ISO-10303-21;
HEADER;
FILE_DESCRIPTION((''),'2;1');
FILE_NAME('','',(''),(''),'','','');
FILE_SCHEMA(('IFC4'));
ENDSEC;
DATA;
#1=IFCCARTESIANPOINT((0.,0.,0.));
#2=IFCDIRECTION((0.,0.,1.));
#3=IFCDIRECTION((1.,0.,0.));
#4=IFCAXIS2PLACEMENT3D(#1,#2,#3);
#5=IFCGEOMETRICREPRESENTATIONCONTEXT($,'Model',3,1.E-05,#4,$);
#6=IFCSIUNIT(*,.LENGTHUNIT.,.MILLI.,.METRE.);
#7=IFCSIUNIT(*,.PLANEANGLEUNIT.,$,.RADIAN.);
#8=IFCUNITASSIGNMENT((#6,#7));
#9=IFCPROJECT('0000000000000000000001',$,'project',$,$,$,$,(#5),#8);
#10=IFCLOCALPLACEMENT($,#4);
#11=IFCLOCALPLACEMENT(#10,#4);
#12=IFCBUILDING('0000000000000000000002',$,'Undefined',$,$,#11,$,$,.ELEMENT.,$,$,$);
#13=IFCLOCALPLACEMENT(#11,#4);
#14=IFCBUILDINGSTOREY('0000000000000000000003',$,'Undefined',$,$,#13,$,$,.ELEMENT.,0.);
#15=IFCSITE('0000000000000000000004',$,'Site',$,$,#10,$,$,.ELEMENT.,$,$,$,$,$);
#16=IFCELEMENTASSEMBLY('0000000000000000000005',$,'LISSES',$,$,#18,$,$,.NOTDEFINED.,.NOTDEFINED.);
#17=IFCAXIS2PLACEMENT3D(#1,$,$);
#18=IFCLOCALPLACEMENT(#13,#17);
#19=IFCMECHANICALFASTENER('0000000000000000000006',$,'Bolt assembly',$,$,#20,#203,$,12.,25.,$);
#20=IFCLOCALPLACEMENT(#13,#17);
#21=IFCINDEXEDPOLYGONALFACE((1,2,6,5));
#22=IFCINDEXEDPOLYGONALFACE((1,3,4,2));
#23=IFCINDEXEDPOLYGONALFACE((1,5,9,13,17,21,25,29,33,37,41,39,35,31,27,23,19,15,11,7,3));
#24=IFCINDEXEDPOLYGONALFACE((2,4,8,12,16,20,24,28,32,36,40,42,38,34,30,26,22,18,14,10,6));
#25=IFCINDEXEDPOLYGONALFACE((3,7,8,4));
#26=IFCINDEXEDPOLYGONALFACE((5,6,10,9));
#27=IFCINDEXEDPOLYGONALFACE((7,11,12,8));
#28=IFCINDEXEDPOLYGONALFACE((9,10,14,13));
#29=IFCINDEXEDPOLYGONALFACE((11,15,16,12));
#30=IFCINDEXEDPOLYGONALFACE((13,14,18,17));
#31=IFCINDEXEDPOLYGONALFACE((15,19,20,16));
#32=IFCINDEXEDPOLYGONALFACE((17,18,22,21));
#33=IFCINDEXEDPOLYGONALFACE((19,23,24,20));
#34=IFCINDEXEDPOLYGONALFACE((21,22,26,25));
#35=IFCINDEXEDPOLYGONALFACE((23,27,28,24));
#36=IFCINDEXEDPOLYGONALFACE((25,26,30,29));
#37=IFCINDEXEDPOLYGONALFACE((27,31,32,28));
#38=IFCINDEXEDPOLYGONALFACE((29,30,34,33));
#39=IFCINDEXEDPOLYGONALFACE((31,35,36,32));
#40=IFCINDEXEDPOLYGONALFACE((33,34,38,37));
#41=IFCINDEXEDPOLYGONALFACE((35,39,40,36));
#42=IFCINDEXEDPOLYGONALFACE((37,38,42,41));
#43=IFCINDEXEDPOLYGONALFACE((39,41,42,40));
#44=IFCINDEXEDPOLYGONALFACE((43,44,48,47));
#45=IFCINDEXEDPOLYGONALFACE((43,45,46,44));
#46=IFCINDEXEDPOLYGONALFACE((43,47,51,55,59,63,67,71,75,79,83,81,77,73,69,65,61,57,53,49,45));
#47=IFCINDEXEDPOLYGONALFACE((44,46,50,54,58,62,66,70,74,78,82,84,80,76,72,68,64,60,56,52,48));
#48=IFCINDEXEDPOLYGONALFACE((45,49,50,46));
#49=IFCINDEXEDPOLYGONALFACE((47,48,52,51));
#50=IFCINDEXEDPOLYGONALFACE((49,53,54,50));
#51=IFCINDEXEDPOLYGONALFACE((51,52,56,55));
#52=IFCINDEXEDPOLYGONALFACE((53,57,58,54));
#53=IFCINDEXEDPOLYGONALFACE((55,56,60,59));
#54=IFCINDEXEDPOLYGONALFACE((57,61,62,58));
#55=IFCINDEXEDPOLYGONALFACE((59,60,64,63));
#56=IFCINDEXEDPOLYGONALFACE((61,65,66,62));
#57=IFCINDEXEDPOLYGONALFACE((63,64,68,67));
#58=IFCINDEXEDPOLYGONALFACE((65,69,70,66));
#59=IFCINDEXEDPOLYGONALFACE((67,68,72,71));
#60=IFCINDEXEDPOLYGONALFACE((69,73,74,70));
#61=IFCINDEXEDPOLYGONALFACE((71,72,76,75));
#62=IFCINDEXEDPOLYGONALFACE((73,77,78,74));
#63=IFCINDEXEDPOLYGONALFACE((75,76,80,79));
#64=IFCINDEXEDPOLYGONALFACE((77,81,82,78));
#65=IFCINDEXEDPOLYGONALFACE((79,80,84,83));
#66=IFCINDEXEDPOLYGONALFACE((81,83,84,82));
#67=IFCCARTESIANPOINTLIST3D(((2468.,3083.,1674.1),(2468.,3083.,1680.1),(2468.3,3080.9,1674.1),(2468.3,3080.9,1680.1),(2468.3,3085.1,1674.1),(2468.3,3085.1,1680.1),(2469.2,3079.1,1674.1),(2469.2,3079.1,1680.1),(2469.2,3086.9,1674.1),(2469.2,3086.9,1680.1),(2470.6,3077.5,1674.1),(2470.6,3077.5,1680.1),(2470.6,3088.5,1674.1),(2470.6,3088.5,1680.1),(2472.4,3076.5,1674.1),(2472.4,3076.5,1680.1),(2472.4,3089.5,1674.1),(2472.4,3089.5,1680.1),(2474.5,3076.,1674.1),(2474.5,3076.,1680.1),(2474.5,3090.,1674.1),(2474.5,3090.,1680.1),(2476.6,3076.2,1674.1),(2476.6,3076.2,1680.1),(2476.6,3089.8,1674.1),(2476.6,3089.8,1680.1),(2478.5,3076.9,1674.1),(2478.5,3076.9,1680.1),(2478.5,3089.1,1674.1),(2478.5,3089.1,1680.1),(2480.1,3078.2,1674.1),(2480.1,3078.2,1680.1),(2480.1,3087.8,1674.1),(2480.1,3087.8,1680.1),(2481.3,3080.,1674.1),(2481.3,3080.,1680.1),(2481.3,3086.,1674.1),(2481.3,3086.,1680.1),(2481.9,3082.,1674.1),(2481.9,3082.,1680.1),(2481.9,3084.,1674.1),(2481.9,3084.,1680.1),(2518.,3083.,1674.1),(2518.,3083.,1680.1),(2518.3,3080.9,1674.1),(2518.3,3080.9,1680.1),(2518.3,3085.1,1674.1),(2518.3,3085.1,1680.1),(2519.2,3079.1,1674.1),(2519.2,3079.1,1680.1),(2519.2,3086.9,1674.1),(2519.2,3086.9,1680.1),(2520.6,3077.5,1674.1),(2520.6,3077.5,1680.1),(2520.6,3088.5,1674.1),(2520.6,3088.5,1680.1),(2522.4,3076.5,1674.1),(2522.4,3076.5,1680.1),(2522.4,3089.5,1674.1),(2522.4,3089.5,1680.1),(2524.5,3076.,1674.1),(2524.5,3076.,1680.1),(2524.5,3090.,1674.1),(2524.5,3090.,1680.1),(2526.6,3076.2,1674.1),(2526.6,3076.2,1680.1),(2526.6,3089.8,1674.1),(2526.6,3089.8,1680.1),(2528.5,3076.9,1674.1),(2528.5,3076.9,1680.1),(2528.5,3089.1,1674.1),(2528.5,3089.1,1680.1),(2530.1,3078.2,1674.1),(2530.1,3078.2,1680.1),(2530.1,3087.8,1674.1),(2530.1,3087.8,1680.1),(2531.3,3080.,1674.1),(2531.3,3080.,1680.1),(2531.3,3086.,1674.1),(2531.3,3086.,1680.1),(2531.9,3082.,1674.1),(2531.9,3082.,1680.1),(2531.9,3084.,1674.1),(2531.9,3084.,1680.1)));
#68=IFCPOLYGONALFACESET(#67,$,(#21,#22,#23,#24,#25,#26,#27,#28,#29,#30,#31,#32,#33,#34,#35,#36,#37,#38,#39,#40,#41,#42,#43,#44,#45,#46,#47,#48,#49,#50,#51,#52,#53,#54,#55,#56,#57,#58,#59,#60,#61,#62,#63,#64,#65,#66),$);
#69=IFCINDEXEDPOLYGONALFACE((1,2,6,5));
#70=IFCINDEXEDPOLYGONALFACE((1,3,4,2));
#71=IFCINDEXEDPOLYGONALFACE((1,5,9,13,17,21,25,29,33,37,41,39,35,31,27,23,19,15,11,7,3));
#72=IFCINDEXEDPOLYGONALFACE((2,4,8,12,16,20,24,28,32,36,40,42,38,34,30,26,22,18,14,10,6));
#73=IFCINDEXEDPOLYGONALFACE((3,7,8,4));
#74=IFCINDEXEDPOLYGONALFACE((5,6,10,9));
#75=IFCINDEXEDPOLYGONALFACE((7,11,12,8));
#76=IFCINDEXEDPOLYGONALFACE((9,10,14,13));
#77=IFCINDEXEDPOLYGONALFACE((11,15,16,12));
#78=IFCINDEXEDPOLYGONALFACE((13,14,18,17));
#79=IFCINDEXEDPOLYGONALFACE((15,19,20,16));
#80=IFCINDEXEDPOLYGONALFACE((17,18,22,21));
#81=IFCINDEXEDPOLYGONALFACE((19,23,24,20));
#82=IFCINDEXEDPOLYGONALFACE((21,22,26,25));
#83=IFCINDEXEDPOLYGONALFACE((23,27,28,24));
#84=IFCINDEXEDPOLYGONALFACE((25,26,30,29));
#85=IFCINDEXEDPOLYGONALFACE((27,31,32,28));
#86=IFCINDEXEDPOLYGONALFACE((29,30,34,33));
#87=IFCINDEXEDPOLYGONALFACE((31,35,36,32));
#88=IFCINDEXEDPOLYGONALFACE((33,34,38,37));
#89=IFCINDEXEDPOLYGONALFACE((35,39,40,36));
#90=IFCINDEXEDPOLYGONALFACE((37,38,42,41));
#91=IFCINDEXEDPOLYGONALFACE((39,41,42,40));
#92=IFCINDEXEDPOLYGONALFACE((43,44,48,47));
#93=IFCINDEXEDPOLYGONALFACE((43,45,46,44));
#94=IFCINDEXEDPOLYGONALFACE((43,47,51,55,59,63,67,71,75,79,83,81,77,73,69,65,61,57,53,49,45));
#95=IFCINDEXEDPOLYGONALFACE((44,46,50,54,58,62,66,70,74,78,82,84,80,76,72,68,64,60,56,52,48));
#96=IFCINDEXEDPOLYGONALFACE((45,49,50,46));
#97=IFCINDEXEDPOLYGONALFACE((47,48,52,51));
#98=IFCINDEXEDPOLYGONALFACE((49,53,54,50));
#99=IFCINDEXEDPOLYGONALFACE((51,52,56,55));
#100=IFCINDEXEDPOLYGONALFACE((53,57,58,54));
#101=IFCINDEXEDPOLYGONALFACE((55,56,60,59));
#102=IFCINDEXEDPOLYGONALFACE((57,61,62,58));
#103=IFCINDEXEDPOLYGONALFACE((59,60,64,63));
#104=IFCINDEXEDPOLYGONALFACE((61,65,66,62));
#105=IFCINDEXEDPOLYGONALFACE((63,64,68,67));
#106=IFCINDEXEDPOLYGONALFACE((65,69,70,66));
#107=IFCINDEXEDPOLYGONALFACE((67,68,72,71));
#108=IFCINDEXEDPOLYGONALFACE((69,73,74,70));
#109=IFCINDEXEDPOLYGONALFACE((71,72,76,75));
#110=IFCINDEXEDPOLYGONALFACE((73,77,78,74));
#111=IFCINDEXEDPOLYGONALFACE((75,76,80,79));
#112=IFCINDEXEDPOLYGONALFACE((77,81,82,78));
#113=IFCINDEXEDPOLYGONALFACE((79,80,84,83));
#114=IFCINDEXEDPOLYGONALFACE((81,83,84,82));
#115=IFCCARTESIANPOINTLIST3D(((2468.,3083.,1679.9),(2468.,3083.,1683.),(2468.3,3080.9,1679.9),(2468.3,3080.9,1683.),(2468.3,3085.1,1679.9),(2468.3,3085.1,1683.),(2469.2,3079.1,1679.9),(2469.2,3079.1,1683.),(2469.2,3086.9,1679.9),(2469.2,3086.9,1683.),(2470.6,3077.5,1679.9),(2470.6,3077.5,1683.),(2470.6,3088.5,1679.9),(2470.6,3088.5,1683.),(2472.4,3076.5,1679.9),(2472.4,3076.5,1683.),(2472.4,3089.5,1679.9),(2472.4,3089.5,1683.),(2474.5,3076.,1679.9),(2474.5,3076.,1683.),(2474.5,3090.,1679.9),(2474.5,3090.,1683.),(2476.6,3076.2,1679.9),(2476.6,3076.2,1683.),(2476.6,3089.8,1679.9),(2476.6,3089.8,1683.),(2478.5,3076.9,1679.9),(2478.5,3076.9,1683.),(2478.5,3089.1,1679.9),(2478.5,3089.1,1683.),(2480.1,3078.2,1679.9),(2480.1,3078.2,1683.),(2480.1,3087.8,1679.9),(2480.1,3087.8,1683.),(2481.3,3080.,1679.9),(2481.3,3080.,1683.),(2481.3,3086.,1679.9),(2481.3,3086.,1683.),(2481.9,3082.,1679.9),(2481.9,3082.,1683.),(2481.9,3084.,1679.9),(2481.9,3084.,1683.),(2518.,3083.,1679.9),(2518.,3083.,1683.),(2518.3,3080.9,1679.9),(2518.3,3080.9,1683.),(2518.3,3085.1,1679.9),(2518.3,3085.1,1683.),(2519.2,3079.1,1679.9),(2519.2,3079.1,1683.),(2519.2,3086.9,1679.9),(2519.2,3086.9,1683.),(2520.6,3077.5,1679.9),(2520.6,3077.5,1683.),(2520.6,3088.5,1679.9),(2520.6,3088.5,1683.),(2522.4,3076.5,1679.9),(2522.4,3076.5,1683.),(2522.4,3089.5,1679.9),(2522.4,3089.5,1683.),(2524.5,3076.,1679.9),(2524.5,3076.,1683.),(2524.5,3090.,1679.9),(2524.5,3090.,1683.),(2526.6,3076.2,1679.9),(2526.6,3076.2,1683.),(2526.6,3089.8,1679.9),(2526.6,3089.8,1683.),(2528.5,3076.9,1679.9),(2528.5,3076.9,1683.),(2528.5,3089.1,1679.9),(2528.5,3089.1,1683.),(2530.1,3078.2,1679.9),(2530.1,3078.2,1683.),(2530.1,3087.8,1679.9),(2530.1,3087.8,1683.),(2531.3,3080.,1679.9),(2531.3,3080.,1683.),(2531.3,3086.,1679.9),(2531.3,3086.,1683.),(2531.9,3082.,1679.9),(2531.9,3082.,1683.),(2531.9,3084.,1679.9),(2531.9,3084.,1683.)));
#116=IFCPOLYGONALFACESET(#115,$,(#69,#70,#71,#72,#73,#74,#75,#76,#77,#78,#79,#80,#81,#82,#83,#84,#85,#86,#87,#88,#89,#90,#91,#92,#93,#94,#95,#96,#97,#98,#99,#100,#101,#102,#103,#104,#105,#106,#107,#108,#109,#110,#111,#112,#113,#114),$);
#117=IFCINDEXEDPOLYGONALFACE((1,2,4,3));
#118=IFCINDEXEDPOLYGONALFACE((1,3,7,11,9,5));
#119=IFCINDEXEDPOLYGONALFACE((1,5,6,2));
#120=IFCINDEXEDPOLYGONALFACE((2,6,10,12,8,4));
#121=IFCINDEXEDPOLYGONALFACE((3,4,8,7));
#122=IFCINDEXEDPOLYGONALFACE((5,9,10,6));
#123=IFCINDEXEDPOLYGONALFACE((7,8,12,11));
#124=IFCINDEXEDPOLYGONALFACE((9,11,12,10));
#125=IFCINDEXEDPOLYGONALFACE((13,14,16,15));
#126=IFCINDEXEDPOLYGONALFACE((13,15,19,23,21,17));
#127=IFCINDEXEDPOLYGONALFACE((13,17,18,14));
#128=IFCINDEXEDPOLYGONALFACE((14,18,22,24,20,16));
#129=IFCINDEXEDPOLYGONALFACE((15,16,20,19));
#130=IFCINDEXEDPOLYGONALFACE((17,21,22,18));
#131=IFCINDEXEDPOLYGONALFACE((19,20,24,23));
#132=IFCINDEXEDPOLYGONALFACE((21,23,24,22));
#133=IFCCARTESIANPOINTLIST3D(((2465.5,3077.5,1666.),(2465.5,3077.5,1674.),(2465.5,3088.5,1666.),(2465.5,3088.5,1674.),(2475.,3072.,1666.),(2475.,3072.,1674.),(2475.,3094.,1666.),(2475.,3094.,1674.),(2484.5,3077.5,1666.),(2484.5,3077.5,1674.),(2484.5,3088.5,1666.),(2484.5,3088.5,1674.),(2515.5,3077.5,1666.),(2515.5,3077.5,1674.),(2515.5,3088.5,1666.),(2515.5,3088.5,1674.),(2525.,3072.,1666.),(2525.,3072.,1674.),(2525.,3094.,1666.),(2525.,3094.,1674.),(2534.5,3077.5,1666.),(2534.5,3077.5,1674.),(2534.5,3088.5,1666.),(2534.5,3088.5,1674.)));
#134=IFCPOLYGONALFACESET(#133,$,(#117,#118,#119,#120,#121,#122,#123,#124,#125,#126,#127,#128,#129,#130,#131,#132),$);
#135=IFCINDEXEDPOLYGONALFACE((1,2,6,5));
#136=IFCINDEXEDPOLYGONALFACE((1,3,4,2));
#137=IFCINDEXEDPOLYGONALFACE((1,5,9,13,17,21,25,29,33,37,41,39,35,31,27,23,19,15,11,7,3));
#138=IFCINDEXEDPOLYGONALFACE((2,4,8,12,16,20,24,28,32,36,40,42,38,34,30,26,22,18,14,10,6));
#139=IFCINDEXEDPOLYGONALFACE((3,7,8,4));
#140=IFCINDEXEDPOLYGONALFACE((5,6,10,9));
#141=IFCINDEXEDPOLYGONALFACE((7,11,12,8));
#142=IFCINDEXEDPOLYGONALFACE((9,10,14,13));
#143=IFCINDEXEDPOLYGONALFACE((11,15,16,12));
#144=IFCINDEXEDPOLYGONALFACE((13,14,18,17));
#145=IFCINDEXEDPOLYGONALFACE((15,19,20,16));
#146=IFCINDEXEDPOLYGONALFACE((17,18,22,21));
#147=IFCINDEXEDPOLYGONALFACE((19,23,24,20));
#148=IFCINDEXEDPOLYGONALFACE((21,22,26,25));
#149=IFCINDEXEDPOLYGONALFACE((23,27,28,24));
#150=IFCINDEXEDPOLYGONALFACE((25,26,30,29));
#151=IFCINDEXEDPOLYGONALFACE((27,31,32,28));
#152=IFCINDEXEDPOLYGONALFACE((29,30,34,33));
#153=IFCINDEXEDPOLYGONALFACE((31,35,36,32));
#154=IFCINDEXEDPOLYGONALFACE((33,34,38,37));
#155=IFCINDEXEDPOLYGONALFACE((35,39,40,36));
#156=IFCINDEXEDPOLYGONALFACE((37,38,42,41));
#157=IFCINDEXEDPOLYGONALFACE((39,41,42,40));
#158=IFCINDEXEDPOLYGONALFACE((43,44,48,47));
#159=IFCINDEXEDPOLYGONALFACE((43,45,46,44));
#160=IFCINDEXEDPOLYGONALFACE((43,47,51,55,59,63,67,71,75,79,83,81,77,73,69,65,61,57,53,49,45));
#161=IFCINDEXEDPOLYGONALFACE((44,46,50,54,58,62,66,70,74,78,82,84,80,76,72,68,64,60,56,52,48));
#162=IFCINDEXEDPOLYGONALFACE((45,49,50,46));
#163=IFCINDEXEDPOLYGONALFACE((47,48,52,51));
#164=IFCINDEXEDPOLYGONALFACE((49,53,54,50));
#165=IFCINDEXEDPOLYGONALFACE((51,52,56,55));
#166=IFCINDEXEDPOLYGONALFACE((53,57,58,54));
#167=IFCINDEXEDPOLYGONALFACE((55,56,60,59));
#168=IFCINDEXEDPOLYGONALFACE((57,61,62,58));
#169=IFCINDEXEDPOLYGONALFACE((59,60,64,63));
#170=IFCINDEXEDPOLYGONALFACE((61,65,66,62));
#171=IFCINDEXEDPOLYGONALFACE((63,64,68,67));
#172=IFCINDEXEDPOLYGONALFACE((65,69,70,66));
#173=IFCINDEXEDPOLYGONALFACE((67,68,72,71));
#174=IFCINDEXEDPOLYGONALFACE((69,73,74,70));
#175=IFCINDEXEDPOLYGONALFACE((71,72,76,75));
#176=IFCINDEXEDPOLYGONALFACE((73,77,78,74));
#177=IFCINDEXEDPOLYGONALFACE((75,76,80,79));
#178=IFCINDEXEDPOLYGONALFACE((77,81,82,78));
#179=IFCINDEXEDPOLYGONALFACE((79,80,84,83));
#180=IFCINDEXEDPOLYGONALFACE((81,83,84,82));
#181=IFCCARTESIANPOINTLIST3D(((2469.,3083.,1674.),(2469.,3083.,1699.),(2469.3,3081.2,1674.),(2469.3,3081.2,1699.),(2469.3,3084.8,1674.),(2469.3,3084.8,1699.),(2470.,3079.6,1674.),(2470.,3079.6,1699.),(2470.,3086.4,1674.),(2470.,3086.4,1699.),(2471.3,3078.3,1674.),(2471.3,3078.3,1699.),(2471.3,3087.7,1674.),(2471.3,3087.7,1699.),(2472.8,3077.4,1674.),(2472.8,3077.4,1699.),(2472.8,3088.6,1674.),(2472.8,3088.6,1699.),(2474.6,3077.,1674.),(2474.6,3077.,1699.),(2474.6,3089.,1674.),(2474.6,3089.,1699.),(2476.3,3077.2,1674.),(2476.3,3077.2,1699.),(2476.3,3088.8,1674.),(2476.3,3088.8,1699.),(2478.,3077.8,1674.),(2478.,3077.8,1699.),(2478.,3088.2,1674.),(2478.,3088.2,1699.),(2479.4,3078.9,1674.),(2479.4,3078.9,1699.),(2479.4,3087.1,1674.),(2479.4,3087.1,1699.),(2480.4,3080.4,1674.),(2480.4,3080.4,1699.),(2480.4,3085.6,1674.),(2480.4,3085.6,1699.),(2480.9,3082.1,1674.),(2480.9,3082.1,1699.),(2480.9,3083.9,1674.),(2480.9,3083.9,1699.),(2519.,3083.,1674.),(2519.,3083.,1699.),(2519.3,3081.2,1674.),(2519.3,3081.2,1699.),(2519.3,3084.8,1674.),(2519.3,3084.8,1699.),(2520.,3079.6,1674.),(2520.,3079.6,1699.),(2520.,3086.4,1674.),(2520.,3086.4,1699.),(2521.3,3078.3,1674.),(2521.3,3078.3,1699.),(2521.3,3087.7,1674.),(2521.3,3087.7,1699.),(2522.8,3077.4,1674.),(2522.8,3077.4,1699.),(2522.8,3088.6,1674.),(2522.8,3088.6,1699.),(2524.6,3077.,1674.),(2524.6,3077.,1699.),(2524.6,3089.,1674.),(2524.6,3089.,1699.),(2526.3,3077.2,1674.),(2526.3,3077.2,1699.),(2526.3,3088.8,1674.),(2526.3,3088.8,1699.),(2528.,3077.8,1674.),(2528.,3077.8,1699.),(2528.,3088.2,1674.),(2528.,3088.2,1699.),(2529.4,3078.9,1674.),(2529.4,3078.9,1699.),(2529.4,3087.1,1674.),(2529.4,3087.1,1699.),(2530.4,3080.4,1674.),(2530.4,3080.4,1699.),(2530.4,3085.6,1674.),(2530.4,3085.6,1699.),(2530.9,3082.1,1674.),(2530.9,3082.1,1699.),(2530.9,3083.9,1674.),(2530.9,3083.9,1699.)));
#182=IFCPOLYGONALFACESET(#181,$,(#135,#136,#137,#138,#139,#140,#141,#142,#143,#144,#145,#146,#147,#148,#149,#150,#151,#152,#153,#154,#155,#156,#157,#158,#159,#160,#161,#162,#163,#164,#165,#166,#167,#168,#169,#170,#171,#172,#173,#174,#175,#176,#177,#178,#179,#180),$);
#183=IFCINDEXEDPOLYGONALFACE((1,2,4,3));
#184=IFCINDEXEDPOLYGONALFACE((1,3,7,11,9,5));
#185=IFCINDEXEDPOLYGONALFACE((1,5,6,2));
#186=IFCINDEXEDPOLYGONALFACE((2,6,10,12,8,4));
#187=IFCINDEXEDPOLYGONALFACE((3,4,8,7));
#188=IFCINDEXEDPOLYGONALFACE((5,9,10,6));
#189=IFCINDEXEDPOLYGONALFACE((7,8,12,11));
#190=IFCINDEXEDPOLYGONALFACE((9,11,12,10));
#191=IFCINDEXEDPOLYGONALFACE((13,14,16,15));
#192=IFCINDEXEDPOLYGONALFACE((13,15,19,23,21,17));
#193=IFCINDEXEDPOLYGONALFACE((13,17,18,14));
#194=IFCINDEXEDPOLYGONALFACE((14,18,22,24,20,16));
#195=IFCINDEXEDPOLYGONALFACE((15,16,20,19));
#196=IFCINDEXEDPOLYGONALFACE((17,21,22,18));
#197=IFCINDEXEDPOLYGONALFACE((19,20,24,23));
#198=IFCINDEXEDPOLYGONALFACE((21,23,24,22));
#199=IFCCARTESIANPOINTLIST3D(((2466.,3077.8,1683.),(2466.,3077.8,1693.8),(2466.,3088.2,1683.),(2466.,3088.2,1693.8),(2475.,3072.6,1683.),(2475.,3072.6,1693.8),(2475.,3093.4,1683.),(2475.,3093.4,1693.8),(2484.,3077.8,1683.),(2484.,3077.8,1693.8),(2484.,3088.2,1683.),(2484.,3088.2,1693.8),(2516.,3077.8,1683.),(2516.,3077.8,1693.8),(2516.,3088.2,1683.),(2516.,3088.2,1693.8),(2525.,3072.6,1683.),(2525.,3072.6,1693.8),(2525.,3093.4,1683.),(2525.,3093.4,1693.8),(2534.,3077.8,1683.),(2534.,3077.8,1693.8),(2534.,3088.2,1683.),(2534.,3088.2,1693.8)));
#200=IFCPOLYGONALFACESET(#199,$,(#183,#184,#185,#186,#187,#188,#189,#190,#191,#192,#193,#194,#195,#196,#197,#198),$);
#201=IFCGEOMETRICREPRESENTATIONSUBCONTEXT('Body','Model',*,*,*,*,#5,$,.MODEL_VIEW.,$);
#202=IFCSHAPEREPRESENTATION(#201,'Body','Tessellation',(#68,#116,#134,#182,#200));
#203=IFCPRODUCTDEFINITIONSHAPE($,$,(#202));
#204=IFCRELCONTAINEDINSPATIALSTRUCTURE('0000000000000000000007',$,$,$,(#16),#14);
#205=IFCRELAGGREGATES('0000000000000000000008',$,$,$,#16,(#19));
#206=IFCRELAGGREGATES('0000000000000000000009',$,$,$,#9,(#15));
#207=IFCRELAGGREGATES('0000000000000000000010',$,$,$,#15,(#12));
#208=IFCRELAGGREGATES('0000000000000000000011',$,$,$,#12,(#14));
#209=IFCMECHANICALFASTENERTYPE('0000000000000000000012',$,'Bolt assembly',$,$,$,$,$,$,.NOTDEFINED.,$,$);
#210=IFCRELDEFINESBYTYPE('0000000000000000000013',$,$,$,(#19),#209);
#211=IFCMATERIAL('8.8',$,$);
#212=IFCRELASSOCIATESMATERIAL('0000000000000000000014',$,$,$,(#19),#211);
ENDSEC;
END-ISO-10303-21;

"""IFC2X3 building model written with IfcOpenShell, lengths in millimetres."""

from ifc_helpers import new_model, si_unit, frame, origin_with_axes, origin_2d_with_axis, place, context, subcontext, project, spatial, polyline, circle, outline, extrude, source, transform, mapped, material, type_object, element, aggregate, save


model = new_model("IFC2X3")

# Units and contexts
model_context = context("Model", 3, precision=1e-05, world=origin_with_axes())
body_context = subcontext(model_context, "Body", "Model", "MODEL_VIEW")
ifc_project = project(units=[si_unit("LENGTHUNIT", "METRE", prefix="MILLI"), si_unit("PLANEANGLEUNIT", "RADIAN")], contexts=[model_context])

# Site, building, storey
site_placement = place(None, origin_with_axes())
site = spatial("IfcSite", under=ifc_project, at=site_placement, Name="Site", CompositionType="ELEMENT")
building_placement = place(site_placement, origin_with_axes())
building = spatial("IfcBuilding", under=site, at=building_placement, Name="Undefined", CompositionType="ELEMENT")
storey_placement = place(building_placement, origin_with_axes())
storey = spatial("IfcBuildingStorey", under=building, at=storey_placement, Name="Undefined", CompositionType="ELEMENT", Elevation=0.0)

# Shared definitions
mechanical_fastener_type = type_object("IfcMechanicalFastenerType", Name="Bolt assembly")
ifc_material_1 = material(Name="8.8")

# Element assembly, mechanical fastener
shared_shape_1 = source(origin_with_axes(), body_context, "Body", "SweptSolid", [
    extrude(circle(Radius=7.0, at=origin_2d_with_axis()), frame((0.0, -5.9, 0.0), z_axis=(0.0, 1.0, 0.0), x_axis=(1.0, 0.0, 0.0)), (0.0, 0.0, 1.0), 6.0),
    extrude(circle(Radius=7.0, at=origin_2d_with_axis()), frame((0.0, -0.1, 0.0), z_axis=(0.0, 1.0, 0.0), x_axis=(1.0, 0.0, 0.0)), (0.0, 0.0, 1.0), 3.1),
    extrude(outline(polyline([(9.5, -5.5), (9.5, 5.5), (0.0, 11.0), (-9.5, 5.5), (-9.5, -5.5), (0.0, -11.0), (9.5, -5.5)])), frame((0.0, -14.0, 0.0), z_axis=(0.0, 1.0, 0.0), x_axis=(1.0, 0.0, 0.0)), (0.0, 0.0, 1.0), 8.0),
    extrude(circle(Radius=6.0, at=origin_2d_with_axis()), frame((0.0, -6.0, 0.0), z_axis=(0.0, 1.0, 0.0), x_axis=(1.0, 0.0, 0.0)), (0.0, 0.0, 1.0), 25.0),
    extrude(outline(polyline([(9.0, -5.2), (9.0, 5.2), (0.0, 10.4), (-9.0, 5.2), (-9.0, -5.2), (0.0, -10.4), (9.0, -5.2)])), frame((0.0, 3.0, 0.0), z_axis=(0.0, 1.0, 0.0), x_axis=(1.0, 0.0, 0.0)), (0.0, 0.0, 1.0), 10.8),
])
assembly_1_placement = place(storey_placement, origin_with_axes())
assembly_1 = element("IfcElementAssembly", 1, at=assembly_1_placement, inside=storey, Name="LISSES", AssemblyPlace="NOTDEFINED", PredefinedType="NOTDEFINED")
mechanical_fastener_1_placement = place(assembly_1_placement, frame((2525.0, 3083.0, 1680.0), z_axis=(0.0, 1.0, 0.0), x_axis=(-1.0, 0.0, 0.0)))
mechanical_fastener_1 = element("IfcMechanicalFastener", 2, at=mechanical_fastener_1_placement, type_object=mechanical_fastener_type, material=ifc_material_1, Name="Bolt assembly", NominalDiameter=12.0, NominalLength=25.0, context=body_context, shape_type="MappedRepresentation", body=[
    mapped(shared_shape_1, transform((0.0, 0.0, 0.0))),
    mapped(shared_shape_1, transform((50.0, 0.0, 0.0))),
])
aggregate(assembly_1, [mechanical_fastener_1])

save(model, "model.ifc")
